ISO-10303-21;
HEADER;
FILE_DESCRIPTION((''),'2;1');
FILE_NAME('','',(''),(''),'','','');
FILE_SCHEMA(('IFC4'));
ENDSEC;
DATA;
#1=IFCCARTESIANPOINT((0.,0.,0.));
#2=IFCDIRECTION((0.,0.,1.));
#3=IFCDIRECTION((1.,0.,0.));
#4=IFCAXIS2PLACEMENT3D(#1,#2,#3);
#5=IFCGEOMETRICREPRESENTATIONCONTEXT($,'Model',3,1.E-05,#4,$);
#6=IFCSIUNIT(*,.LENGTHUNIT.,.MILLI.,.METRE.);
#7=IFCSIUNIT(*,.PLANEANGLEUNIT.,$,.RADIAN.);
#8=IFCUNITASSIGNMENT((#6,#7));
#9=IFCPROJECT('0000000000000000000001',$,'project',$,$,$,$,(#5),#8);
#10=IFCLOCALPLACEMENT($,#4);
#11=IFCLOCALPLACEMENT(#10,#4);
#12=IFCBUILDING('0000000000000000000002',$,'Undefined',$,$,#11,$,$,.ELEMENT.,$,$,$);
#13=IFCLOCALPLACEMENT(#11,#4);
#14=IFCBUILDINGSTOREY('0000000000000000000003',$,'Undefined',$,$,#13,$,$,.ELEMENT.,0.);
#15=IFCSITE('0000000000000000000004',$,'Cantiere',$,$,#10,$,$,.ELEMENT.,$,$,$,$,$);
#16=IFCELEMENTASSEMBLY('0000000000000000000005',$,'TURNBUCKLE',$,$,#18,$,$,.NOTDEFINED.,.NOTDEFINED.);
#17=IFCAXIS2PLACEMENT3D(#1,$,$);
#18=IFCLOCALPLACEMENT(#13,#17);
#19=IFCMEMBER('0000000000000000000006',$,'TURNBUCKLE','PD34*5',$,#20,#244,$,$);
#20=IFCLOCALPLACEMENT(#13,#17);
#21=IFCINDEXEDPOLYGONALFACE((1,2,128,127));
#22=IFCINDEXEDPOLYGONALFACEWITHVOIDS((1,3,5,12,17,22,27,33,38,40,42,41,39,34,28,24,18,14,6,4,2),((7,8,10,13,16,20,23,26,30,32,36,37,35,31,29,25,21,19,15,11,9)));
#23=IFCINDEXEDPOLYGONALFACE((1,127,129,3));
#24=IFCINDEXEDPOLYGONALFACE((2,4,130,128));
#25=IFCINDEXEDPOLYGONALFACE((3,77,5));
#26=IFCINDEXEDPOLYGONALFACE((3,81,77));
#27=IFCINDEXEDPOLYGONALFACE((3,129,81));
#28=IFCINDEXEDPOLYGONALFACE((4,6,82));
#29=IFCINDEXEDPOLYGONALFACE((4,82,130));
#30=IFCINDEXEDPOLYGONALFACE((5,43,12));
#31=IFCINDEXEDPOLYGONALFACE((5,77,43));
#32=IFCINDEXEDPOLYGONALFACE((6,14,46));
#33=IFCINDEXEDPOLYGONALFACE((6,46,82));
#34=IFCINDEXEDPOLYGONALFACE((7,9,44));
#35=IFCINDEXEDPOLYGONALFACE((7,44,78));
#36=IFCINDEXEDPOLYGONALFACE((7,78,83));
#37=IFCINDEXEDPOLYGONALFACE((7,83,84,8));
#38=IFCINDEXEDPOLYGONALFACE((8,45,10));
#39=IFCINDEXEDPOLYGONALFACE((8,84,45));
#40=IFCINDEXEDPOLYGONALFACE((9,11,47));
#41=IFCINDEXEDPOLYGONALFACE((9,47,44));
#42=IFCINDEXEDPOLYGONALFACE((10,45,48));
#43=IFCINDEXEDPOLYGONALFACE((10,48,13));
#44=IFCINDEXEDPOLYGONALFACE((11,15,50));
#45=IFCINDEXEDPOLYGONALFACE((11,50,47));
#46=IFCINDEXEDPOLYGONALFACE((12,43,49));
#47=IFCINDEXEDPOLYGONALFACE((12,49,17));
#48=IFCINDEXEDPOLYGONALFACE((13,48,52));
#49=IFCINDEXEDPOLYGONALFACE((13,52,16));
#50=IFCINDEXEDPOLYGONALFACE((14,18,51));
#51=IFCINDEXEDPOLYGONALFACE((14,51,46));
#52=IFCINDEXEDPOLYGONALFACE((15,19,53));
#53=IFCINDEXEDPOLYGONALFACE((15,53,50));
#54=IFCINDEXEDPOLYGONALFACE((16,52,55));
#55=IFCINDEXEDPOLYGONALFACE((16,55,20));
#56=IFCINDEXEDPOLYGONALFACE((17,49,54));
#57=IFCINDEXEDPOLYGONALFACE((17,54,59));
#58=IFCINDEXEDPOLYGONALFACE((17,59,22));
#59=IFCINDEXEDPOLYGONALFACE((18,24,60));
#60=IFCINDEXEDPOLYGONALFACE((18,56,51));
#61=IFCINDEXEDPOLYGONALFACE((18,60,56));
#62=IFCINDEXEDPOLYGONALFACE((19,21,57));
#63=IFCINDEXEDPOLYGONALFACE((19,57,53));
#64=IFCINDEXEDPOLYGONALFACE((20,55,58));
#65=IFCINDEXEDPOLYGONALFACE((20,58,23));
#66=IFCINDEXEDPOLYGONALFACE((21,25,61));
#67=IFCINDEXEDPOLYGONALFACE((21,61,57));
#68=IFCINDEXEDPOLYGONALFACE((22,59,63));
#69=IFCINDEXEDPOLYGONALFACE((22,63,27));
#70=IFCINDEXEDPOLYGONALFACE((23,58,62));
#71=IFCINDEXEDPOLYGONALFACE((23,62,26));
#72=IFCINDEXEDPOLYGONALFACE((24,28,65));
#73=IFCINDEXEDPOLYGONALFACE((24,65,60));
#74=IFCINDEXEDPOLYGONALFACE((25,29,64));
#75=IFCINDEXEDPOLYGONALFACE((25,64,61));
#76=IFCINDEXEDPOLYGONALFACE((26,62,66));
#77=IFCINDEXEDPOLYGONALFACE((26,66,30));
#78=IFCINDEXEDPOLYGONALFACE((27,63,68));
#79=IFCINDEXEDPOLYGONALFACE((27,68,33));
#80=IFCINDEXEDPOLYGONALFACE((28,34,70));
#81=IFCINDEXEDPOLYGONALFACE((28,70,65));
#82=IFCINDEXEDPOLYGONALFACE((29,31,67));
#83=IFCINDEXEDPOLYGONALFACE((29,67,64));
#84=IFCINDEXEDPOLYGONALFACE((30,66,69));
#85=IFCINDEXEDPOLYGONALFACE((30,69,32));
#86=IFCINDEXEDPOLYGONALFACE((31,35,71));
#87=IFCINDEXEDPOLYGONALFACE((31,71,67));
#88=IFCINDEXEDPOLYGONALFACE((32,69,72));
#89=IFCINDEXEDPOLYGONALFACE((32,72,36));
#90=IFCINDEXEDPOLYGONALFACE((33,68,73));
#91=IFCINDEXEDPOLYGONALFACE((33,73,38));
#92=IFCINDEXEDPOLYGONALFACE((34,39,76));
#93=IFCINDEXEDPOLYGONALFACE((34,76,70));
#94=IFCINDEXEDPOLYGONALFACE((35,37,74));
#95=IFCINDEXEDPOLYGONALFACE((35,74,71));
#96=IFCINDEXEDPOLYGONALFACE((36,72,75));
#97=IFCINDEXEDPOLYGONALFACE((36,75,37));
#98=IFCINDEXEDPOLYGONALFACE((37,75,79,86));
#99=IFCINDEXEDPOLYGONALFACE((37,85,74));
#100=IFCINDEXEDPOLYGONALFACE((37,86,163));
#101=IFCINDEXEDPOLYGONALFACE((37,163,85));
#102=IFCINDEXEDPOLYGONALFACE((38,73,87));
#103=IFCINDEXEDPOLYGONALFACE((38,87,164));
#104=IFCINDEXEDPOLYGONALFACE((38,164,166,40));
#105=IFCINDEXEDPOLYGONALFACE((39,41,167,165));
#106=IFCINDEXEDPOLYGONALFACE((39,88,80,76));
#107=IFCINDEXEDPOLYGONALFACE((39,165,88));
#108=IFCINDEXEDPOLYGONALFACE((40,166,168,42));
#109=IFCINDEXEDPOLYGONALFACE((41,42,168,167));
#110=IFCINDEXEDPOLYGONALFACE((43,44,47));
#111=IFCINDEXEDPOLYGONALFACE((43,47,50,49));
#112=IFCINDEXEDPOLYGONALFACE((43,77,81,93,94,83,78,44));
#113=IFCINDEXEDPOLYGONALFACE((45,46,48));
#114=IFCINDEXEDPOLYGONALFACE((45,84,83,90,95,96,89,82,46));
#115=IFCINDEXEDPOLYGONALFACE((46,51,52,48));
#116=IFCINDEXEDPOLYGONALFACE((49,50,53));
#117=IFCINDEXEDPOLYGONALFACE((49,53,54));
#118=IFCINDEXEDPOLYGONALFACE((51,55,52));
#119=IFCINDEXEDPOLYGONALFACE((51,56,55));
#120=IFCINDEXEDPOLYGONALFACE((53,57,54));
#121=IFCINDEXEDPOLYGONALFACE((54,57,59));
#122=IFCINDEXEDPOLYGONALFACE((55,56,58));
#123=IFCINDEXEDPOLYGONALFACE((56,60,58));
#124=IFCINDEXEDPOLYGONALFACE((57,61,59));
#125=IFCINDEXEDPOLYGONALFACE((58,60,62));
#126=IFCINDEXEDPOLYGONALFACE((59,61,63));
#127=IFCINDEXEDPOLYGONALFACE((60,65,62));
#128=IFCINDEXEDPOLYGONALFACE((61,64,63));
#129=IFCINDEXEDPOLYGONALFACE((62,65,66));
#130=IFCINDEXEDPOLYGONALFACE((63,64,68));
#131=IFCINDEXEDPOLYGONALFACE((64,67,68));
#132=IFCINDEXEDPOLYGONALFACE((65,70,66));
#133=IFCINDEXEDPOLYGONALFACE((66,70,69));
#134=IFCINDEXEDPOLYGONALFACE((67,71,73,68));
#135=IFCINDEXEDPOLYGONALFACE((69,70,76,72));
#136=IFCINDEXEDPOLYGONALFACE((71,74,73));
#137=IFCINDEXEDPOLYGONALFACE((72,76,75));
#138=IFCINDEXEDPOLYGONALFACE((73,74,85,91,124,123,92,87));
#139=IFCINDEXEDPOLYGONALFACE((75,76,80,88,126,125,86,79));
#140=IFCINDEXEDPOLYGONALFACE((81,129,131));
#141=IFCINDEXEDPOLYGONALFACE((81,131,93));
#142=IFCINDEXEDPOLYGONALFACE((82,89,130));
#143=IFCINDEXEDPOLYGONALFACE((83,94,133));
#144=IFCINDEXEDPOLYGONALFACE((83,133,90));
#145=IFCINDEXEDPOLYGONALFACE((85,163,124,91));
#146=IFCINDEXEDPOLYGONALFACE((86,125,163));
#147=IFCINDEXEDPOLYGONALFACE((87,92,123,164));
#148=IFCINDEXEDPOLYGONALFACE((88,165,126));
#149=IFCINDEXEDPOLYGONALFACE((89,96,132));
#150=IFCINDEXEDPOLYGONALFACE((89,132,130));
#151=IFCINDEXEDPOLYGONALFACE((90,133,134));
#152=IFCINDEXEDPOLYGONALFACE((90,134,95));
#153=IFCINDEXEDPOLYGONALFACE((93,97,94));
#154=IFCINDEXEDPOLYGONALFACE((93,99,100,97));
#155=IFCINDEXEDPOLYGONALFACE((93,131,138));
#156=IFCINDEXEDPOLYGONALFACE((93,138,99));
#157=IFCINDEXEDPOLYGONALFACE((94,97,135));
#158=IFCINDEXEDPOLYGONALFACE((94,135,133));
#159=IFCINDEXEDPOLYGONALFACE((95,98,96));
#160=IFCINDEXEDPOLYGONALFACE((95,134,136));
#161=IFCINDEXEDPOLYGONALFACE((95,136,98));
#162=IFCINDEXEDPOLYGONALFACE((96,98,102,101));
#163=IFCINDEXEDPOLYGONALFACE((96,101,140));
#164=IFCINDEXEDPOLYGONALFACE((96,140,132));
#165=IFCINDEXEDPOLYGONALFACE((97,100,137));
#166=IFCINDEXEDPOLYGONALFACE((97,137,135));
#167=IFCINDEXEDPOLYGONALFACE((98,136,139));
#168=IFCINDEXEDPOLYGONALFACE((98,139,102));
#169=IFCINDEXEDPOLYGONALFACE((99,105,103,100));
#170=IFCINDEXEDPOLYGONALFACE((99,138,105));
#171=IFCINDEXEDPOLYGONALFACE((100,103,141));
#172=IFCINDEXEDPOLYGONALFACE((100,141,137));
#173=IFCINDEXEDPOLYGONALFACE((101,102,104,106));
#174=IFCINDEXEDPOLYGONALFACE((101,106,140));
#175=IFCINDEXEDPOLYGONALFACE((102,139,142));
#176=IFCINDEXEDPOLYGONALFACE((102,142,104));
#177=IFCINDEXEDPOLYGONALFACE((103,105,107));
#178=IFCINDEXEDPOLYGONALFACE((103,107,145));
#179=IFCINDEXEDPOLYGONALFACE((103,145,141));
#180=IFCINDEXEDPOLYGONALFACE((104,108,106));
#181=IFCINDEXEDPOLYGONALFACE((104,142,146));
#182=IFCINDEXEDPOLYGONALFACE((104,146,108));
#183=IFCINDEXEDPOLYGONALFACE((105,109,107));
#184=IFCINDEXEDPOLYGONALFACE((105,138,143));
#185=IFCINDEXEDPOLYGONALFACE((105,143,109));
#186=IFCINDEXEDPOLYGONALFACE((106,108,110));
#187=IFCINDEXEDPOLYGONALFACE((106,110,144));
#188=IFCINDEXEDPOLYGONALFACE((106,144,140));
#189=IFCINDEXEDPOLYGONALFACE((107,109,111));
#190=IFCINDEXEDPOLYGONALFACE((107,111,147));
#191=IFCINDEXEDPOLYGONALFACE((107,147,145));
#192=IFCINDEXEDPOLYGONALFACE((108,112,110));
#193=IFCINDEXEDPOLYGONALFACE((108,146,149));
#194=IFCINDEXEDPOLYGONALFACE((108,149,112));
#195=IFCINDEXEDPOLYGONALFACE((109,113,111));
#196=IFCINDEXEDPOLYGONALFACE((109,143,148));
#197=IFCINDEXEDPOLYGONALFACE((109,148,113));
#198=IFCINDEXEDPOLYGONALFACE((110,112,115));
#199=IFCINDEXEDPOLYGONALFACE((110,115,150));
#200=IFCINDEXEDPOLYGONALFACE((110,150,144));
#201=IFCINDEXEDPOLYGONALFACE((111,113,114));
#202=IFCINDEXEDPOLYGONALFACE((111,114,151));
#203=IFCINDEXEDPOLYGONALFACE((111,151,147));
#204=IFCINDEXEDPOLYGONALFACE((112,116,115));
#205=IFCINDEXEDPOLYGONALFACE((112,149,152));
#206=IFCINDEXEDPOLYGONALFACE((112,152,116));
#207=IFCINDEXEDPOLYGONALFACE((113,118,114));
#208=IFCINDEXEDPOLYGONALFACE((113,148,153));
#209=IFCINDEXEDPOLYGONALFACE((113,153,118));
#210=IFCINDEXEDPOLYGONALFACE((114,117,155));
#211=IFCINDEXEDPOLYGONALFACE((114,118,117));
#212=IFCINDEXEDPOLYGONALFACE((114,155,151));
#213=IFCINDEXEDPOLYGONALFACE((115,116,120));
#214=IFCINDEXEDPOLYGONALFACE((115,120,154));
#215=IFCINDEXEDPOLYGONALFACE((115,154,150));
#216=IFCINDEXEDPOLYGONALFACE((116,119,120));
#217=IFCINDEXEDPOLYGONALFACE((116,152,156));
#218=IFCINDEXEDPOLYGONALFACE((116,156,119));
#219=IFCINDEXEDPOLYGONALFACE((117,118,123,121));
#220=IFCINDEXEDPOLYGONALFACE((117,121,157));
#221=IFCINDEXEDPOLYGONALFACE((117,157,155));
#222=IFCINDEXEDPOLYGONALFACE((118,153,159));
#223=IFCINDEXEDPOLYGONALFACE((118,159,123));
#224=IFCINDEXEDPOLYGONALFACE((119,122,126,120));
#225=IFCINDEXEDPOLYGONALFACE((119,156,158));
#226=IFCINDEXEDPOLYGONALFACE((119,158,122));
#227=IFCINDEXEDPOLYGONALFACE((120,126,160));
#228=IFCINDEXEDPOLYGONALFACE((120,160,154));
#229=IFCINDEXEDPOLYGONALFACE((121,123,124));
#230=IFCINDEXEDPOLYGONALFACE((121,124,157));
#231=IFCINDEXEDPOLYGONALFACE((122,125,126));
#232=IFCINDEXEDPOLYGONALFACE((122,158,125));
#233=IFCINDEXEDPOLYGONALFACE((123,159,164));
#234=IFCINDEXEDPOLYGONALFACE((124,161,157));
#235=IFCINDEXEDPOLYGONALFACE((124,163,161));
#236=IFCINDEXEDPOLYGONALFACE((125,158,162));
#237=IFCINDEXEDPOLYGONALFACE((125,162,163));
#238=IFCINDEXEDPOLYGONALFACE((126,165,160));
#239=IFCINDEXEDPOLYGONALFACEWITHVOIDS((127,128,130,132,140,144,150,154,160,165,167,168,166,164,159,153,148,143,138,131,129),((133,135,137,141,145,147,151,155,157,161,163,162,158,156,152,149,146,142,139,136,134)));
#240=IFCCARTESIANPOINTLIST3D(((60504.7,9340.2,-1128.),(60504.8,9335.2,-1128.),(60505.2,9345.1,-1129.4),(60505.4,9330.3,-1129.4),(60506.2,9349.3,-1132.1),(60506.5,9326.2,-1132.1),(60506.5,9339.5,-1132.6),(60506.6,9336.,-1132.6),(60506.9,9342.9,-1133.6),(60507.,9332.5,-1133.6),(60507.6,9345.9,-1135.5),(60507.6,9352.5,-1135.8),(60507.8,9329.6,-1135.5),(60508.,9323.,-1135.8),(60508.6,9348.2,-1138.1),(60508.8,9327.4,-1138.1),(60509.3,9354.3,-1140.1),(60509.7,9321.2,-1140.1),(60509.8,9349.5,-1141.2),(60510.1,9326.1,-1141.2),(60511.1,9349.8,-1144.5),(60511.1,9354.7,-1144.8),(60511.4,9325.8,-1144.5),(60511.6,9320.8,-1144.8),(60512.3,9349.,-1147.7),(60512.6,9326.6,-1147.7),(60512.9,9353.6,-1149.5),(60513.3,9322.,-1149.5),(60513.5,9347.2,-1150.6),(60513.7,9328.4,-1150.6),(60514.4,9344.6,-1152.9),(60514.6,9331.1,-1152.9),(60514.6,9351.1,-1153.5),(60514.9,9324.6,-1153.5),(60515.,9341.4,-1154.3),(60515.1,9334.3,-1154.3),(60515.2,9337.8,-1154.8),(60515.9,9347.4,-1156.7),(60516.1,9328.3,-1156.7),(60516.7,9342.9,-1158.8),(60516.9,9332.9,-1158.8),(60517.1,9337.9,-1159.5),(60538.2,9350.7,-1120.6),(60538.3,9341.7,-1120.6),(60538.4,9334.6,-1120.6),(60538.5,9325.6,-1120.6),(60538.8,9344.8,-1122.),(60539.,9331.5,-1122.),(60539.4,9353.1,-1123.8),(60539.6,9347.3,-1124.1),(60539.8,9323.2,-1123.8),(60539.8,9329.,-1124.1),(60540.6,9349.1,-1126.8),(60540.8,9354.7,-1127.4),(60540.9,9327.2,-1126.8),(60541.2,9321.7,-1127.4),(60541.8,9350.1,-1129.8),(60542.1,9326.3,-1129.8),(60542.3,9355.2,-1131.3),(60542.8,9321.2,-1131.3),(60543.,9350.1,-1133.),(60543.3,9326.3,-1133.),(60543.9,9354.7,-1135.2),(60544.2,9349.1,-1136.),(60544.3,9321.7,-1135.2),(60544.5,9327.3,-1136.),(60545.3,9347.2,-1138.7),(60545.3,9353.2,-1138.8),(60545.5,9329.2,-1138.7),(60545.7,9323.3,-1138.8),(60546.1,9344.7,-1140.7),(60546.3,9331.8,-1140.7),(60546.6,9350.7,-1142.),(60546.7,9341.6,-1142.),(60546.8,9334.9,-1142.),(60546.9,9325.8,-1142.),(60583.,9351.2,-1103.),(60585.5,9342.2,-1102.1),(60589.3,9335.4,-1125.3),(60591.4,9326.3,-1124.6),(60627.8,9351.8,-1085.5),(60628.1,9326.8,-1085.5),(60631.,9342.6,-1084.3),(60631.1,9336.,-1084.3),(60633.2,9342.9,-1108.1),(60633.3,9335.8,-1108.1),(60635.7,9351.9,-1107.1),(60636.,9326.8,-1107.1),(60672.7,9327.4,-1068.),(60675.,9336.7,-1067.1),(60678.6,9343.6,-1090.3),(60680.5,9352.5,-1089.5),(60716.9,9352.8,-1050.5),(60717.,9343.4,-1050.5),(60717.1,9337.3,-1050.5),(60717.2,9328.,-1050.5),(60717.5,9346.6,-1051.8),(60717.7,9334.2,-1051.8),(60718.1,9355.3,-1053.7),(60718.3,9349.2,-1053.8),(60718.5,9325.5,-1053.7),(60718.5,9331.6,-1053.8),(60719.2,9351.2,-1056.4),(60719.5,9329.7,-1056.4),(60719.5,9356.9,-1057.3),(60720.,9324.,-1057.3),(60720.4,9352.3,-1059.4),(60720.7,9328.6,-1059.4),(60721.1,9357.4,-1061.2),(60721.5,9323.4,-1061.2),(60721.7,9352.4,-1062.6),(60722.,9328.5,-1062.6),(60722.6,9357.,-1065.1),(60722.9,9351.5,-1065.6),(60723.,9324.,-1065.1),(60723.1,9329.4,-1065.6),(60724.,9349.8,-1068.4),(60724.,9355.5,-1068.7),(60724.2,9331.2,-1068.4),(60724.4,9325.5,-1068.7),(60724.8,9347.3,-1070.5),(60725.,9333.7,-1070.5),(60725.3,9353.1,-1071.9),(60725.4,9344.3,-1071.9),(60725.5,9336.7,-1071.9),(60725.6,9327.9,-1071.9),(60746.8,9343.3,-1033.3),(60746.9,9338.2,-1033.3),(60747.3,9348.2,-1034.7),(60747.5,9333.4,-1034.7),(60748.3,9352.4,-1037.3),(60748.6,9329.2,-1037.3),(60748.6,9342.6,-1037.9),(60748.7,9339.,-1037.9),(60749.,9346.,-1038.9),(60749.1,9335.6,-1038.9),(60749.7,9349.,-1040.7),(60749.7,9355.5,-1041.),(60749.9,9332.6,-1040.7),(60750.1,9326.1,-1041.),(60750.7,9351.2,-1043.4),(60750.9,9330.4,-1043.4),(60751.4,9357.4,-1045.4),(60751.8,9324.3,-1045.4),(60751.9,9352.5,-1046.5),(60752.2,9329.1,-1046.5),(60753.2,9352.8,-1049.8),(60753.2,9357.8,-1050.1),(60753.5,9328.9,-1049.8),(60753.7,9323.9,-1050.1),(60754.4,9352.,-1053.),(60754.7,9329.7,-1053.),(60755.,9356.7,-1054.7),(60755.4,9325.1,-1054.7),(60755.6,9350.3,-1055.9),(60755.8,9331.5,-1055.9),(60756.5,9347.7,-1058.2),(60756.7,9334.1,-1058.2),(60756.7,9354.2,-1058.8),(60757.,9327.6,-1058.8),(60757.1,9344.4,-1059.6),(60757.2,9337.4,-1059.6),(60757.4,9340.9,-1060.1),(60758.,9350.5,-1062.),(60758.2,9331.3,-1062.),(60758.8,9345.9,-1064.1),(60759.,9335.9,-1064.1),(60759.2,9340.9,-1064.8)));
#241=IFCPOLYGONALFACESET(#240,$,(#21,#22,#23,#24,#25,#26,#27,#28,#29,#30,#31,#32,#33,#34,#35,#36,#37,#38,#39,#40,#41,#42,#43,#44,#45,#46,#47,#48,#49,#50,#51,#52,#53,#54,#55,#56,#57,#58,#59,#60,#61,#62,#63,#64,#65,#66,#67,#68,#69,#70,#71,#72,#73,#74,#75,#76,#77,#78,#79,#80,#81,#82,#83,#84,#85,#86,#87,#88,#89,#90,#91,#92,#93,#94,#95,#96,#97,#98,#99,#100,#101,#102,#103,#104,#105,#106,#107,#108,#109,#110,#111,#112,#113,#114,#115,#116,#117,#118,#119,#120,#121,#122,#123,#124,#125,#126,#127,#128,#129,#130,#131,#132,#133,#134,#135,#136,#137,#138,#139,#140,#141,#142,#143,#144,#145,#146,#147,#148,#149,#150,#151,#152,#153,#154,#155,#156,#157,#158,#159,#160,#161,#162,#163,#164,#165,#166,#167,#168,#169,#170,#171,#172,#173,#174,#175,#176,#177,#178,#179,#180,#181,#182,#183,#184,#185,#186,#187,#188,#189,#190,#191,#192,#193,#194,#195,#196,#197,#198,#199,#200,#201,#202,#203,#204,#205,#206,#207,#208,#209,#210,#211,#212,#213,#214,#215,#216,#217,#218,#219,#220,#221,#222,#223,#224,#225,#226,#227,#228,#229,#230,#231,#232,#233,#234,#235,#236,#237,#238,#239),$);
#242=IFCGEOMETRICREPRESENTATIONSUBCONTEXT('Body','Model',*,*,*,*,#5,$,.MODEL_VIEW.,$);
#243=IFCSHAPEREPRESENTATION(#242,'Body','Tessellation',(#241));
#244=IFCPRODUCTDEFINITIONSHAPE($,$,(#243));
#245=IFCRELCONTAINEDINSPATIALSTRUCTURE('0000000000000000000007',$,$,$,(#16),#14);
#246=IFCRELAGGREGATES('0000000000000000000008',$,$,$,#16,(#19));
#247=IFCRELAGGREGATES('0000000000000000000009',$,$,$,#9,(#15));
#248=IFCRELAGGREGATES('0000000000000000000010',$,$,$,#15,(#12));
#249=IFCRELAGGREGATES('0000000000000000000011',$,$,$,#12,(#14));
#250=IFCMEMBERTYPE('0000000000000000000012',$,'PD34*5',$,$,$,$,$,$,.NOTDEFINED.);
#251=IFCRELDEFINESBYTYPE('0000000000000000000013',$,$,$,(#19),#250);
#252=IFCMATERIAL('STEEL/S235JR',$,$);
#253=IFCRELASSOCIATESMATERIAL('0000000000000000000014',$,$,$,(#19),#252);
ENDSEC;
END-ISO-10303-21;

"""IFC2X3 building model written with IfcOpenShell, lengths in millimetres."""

from ifc_helpers import new_model, si_unit, frame, origin_with_axes, origin_2d_with_axis, place, context, subcontext, project, spatial, rectangle, hollow_circle, extrude, boolean, material, type_object, element, aggregate, save


model = new_model("IFC2X3")

# Units and contexts
model_context = context("Model", 3, precision=1e-05, world=origin_with_axes())
body_context = subcontext(model_context, "Body", "Model", "MODEL_VIEW")
ifc_project = project(units=[si_unit("LENGTHUNIT", "METRE", prefix="MILLI"), si_unit("PLANEANGLEUNIT", "RADIAN")], contexts=[model_context])

# Site, building, storey
site_placement = place(None, origin_with_axes())
site = spatial("IfcSite", under=ifc_project, at=site_placement, Name="Cantiere", CompositionType="ELEMENT")
building_placement = place(site_placement, origin_with_axes())
building = spatial("IfcBuilding", under=site, at=building_placement, Name="Undefined", CompositionType="ELEMENT")
storey_placement = place(building_placement, origin_with_axes())
storey = spatial("IfcBuildingStorey", under=building, at=storey_placement, Name="Undefined", CompositionType="ELEMENT", Elevation=0.0)

# Shared definitions
ifc_material_1 = material(Name="STEEL/S235JR")

# Element assembly, member
assembly_1_placement = place(storey_placement, origin_with_axes())
assembly_1 = element("IfcElementAssembly", 1, at=assembly_1_placement, inside=storey, Name="TURNBUCKLE", AssemblyPlace="NOTDEFINED", PredefinedType="NOTDEFINED")
member_type = type_object("IfcMemberType", Name="PD34*5", PredefinedType="NOTDEFINED")
member_1_placement = place(assembly_1_placement, frame((60753.0, 9340.8, -1048.9), z_axis=(-0.012617, 0.99992, 0.0), x_axis=(-0.931196, -0.01175, -0.36433)))
member_1 = element("IfcMember", 2, at=member_1_placement, type_object=member_type, material=ifc_material_1, Name="TURNBUCKLE", Description="PD34*5", context=body_context, shape_type="CSG", body=[
    boolean("DIFFERENCE", extrude(hollow_circle(Radius=17.0, WallThickness=5.0, at=origin_2d_with_axis()), frame((260.0, 0.0, 0.0), z_axis=(-1.0, 0.0, 0.0), x_axis=(0.0, -1.0, 0.0)), (0.0, 0.0, 1.0), 260.0), extrude(rectangle(XDim=23.0, YDim=68.0, at=origin_2d_with_axis()), frame((226.0, 0.0, 0.0), z_axis=(-1.0, 0.000733, 0.0), x_axis=(-0.000733, -1.0, 0.0)), (0.0, 0.0, 1.0), 192.0)),
])
aggregate(assembly_1, [member_1])

save(model, "model.ifc")
